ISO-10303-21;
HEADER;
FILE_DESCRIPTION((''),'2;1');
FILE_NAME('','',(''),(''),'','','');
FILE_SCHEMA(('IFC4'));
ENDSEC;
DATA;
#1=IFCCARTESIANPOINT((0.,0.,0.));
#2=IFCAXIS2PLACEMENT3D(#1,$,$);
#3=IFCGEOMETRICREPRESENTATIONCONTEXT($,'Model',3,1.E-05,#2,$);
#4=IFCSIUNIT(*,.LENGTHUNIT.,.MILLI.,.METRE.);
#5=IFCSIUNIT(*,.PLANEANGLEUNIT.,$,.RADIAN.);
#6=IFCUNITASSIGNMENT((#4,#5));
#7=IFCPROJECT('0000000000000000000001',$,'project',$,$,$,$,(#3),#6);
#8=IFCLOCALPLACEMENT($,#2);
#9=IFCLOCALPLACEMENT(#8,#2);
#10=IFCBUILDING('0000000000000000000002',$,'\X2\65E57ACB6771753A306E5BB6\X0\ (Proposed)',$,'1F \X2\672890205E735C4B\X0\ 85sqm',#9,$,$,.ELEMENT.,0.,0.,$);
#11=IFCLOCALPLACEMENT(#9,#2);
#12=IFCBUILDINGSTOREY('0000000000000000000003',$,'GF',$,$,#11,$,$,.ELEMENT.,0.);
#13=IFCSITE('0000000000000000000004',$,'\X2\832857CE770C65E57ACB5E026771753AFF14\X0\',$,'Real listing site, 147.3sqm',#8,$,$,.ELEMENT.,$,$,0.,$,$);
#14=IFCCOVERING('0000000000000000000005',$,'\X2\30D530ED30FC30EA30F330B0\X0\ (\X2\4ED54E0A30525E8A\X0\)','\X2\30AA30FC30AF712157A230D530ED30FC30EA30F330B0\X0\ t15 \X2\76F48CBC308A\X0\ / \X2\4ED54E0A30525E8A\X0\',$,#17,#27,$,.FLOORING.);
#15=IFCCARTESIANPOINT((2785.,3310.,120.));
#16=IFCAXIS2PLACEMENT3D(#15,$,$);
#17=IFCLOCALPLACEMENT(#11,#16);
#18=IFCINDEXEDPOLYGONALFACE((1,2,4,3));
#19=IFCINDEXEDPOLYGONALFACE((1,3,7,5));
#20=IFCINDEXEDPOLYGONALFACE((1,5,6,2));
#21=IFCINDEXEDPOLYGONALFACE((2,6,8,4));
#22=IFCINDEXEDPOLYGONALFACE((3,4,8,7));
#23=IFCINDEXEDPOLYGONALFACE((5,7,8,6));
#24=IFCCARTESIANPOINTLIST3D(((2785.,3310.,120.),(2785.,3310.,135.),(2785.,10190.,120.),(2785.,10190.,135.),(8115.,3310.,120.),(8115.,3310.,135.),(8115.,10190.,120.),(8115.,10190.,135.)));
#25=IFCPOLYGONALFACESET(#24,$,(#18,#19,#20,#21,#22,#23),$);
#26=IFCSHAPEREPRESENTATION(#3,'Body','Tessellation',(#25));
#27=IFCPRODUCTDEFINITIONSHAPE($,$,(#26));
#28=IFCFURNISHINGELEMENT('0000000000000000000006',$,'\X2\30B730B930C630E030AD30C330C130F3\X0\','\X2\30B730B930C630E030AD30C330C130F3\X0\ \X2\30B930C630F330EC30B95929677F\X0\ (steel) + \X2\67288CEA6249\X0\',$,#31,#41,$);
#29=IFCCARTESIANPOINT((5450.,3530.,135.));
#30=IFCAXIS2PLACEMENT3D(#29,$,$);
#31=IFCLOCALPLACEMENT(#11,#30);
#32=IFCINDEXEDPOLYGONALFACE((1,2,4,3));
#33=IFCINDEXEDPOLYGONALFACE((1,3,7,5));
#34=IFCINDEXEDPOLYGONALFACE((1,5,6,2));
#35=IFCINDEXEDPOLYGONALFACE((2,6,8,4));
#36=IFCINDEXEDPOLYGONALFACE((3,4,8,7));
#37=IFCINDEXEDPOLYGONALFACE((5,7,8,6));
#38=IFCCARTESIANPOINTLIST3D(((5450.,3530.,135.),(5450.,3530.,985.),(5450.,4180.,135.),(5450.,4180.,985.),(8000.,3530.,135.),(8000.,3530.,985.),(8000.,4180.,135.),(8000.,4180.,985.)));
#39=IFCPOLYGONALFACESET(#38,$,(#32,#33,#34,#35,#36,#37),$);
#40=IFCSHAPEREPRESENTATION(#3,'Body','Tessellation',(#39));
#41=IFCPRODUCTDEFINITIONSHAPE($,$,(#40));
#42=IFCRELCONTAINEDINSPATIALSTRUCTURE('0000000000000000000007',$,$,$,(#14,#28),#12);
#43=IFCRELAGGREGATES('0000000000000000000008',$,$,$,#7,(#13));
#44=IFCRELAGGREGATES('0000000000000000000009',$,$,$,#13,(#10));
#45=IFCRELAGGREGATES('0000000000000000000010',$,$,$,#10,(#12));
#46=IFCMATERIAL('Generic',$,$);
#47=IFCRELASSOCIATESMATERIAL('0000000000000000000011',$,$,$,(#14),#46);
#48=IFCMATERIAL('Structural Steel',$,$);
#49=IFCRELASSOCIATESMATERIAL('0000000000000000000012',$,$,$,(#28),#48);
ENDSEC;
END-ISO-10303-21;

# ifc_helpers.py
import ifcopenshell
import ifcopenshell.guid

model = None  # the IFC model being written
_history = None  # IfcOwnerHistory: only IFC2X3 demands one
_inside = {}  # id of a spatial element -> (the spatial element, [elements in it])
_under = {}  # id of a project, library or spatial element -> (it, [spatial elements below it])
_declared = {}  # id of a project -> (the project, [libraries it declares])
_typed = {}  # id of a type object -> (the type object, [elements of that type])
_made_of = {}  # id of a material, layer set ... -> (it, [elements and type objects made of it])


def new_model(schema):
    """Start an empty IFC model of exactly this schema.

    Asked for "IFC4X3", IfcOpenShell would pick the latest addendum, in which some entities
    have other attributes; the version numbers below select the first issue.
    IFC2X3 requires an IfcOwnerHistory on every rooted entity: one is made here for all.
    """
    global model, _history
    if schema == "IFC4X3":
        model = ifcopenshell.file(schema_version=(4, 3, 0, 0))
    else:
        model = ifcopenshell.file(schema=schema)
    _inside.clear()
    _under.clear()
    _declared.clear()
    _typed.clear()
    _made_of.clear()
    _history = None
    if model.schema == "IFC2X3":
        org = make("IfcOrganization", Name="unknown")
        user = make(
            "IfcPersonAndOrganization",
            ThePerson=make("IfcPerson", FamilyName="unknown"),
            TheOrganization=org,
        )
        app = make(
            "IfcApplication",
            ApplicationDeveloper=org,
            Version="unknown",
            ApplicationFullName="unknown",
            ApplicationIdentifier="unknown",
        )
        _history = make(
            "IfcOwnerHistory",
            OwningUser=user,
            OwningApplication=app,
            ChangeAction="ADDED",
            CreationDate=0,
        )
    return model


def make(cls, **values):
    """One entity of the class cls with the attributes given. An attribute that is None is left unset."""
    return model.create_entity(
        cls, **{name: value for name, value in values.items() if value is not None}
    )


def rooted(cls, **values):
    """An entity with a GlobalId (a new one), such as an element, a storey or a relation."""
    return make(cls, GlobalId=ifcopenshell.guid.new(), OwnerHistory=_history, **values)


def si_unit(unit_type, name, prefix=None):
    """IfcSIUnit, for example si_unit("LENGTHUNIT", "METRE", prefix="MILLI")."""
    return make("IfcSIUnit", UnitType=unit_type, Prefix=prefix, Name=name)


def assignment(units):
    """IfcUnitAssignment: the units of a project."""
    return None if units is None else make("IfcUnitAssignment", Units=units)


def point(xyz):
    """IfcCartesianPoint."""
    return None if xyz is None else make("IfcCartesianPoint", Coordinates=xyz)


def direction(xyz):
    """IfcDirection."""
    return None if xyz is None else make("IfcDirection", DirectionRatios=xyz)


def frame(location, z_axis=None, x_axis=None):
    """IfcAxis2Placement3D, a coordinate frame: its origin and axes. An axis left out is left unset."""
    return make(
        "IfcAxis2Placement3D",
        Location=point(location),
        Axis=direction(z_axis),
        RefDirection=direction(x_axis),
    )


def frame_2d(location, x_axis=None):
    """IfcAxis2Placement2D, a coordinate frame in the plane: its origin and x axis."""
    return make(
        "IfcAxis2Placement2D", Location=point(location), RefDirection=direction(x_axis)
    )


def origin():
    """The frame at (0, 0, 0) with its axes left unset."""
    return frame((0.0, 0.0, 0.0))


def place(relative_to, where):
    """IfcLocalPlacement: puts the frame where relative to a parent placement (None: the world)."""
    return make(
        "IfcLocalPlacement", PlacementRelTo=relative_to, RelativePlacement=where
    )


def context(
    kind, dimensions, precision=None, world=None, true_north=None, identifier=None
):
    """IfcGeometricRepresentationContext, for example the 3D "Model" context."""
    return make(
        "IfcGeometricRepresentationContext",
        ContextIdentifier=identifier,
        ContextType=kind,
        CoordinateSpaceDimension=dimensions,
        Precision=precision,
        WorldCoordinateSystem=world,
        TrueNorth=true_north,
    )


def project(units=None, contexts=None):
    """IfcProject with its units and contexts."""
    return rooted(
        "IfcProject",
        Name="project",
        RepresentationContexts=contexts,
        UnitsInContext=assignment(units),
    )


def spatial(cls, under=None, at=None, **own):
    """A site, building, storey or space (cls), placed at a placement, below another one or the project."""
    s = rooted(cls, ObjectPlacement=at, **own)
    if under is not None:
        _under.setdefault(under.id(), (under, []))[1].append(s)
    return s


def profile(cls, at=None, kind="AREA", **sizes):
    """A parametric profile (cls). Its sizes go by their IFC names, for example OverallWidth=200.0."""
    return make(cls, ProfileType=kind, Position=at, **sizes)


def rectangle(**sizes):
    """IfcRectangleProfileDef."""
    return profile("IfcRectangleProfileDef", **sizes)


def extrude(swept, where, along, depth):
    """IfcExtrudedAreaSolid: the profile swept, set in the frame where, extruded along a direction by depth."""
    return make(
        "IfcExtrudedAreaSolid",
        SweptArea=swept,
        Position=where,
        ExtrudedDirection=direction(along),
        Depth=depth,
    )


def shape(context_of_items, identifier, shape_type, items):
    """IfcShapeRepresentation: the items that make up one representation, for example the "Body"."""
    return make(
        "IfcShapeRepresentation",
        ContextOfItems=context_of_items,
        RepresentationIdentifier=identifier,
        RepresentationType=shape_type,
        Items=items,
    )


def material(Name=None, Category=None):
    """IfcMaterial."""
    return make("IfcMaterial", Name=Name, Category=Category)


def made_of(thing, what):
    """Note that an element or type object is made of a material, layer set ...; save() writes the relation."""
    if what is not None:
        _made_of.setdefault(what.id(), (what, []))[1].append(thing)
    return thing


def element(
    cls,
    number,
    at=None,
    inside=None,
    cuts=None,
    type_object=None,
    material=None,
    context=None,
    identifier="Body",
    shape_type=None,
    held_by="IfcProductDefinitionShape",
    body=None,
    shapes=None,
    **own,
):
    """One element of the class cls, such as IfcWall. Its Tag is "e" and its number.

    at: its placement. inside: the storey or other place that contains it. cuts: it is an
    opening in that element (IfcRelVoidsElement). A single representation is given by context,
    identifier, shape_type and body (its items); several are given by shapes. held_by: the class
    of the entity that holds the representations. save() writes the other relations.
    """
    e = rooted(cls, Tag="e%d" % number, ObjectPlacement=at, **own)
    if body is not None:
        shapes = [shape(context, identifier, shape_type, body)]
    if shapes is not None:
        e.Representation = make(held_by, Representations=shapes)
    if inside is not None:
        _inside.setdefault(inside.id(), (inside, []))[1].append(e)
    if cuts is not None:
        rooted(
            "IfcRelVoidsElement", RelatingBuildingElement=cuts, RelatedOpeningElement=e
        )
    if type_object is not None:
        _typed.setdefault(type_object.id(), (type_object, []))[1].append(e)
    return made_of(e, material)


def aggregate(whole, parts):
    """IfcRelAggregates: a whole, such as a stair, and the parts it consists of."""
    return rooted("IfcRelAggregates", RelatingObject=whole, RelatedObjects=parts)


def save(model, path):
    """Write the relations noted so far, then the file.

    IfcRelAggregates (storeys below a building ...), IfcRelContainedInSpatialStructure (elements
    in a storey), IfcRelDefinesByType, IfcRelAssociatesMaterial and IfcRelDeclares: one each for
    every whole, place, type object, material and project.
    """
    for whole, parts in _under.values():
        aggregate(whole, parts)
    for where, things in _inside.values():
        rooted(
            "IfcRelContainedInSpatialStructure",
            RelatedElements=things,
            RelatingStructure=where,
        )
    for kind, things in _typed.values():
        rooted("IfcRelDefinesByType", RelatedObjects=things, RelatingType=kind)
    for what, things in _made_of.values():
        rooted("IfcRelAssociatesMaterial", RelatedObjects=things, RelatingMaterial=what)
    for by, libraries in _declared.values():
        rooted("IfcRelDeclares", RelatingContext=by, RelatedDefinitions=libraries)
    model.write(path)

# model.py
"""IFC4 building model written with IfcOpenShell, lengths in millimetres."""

from ifc_helpers import new_model, si_unit, frame, frame_2d, origin, place, context, project, spatial, rectangle, extrude, material, element, save


model = new_model("IFC4")

# Units and contexts
model_context = context("Model", 3, precision=1e-05, world=origin())
ifc_project = project(units=[si_unit("LENGTHUNIT", "METRE", prefix="MILLI"), si_unit("PLANEANGLEUNIT", "RADIAN")], contexts=[model_context])

# Site, building, storey
site_placement = place(None, origin())
site = spatial("IfcSite", under=ifc_project, at=site_placement, Name="茨城県日立市東町４", ObjectType="Real listing site, 147.3sqm", CompositionType="ELEMENT", RefElevation=0.0)
building_placement = place(site_placement, origin())
building = spatial("IfcBuilding", under=site, at=building_placement, Name="日立東町の家 (Proposed)", ObjectType="1F 木造平屋 85sqm", CompositionType="ELEMENT", ElevationOfRefHeight=0.0, ElevationOfTerrain=0.0)
storey_placement = place(building_placement, origin())
storey = spatial("IfcBuildingStorey", under=building, at=storey_placement, Name="GF", CompositionType="ELEMENT", Elevation=0.0)

# Shared definitions
ifc_material_1 = material(Name="Generic")

# Covering
covering_placement = place(storey_placement, frame((2785.0, 3310.0, 120.0)))
element("IfcCovering", 1, at=covering_placement, inside=storey, material=ifc_material_1, Name="フローリング (仕上げ床)", Description="オーク無垢フローリング t15 直貼り / 仕上げ床", PredefinedType="FLOORING", context=model_context, shape_type="SweptSolid", body=[
    extrude(rectangle(XDim=5330.0, YDim=6880.0, at=frame_2d((2665.0, 3440.0))), frame((2785.0, 3310.0, 120.0)), (0.0, 0.0, 1.0), 15.0),
])

# Furnishing element
ifc_material_2 = material(Name="Structural Steel")
furnishing_placement = place(storey_placement, frame((5450.0, 3530.0, 135.0)))
element("IfcFurnishingElement", 2, at=furnishing_placement, inside=storey, material=ifc_material_2, Name="システムキッチン", Description="システムキッチン ステンレス天板 (steel) + 木質扉", context=model_context, shape_type="SweptSolid", body=[
    extrude(rectangle(XDim=2550.0, YDim=650.0, at=frame_2d((1275.0, 325.0))), frame((5450.0, 3530.0, 135.0)), (0.0, 0.0, 1.0), 850.0),
])

save(model, "model.ifc")
